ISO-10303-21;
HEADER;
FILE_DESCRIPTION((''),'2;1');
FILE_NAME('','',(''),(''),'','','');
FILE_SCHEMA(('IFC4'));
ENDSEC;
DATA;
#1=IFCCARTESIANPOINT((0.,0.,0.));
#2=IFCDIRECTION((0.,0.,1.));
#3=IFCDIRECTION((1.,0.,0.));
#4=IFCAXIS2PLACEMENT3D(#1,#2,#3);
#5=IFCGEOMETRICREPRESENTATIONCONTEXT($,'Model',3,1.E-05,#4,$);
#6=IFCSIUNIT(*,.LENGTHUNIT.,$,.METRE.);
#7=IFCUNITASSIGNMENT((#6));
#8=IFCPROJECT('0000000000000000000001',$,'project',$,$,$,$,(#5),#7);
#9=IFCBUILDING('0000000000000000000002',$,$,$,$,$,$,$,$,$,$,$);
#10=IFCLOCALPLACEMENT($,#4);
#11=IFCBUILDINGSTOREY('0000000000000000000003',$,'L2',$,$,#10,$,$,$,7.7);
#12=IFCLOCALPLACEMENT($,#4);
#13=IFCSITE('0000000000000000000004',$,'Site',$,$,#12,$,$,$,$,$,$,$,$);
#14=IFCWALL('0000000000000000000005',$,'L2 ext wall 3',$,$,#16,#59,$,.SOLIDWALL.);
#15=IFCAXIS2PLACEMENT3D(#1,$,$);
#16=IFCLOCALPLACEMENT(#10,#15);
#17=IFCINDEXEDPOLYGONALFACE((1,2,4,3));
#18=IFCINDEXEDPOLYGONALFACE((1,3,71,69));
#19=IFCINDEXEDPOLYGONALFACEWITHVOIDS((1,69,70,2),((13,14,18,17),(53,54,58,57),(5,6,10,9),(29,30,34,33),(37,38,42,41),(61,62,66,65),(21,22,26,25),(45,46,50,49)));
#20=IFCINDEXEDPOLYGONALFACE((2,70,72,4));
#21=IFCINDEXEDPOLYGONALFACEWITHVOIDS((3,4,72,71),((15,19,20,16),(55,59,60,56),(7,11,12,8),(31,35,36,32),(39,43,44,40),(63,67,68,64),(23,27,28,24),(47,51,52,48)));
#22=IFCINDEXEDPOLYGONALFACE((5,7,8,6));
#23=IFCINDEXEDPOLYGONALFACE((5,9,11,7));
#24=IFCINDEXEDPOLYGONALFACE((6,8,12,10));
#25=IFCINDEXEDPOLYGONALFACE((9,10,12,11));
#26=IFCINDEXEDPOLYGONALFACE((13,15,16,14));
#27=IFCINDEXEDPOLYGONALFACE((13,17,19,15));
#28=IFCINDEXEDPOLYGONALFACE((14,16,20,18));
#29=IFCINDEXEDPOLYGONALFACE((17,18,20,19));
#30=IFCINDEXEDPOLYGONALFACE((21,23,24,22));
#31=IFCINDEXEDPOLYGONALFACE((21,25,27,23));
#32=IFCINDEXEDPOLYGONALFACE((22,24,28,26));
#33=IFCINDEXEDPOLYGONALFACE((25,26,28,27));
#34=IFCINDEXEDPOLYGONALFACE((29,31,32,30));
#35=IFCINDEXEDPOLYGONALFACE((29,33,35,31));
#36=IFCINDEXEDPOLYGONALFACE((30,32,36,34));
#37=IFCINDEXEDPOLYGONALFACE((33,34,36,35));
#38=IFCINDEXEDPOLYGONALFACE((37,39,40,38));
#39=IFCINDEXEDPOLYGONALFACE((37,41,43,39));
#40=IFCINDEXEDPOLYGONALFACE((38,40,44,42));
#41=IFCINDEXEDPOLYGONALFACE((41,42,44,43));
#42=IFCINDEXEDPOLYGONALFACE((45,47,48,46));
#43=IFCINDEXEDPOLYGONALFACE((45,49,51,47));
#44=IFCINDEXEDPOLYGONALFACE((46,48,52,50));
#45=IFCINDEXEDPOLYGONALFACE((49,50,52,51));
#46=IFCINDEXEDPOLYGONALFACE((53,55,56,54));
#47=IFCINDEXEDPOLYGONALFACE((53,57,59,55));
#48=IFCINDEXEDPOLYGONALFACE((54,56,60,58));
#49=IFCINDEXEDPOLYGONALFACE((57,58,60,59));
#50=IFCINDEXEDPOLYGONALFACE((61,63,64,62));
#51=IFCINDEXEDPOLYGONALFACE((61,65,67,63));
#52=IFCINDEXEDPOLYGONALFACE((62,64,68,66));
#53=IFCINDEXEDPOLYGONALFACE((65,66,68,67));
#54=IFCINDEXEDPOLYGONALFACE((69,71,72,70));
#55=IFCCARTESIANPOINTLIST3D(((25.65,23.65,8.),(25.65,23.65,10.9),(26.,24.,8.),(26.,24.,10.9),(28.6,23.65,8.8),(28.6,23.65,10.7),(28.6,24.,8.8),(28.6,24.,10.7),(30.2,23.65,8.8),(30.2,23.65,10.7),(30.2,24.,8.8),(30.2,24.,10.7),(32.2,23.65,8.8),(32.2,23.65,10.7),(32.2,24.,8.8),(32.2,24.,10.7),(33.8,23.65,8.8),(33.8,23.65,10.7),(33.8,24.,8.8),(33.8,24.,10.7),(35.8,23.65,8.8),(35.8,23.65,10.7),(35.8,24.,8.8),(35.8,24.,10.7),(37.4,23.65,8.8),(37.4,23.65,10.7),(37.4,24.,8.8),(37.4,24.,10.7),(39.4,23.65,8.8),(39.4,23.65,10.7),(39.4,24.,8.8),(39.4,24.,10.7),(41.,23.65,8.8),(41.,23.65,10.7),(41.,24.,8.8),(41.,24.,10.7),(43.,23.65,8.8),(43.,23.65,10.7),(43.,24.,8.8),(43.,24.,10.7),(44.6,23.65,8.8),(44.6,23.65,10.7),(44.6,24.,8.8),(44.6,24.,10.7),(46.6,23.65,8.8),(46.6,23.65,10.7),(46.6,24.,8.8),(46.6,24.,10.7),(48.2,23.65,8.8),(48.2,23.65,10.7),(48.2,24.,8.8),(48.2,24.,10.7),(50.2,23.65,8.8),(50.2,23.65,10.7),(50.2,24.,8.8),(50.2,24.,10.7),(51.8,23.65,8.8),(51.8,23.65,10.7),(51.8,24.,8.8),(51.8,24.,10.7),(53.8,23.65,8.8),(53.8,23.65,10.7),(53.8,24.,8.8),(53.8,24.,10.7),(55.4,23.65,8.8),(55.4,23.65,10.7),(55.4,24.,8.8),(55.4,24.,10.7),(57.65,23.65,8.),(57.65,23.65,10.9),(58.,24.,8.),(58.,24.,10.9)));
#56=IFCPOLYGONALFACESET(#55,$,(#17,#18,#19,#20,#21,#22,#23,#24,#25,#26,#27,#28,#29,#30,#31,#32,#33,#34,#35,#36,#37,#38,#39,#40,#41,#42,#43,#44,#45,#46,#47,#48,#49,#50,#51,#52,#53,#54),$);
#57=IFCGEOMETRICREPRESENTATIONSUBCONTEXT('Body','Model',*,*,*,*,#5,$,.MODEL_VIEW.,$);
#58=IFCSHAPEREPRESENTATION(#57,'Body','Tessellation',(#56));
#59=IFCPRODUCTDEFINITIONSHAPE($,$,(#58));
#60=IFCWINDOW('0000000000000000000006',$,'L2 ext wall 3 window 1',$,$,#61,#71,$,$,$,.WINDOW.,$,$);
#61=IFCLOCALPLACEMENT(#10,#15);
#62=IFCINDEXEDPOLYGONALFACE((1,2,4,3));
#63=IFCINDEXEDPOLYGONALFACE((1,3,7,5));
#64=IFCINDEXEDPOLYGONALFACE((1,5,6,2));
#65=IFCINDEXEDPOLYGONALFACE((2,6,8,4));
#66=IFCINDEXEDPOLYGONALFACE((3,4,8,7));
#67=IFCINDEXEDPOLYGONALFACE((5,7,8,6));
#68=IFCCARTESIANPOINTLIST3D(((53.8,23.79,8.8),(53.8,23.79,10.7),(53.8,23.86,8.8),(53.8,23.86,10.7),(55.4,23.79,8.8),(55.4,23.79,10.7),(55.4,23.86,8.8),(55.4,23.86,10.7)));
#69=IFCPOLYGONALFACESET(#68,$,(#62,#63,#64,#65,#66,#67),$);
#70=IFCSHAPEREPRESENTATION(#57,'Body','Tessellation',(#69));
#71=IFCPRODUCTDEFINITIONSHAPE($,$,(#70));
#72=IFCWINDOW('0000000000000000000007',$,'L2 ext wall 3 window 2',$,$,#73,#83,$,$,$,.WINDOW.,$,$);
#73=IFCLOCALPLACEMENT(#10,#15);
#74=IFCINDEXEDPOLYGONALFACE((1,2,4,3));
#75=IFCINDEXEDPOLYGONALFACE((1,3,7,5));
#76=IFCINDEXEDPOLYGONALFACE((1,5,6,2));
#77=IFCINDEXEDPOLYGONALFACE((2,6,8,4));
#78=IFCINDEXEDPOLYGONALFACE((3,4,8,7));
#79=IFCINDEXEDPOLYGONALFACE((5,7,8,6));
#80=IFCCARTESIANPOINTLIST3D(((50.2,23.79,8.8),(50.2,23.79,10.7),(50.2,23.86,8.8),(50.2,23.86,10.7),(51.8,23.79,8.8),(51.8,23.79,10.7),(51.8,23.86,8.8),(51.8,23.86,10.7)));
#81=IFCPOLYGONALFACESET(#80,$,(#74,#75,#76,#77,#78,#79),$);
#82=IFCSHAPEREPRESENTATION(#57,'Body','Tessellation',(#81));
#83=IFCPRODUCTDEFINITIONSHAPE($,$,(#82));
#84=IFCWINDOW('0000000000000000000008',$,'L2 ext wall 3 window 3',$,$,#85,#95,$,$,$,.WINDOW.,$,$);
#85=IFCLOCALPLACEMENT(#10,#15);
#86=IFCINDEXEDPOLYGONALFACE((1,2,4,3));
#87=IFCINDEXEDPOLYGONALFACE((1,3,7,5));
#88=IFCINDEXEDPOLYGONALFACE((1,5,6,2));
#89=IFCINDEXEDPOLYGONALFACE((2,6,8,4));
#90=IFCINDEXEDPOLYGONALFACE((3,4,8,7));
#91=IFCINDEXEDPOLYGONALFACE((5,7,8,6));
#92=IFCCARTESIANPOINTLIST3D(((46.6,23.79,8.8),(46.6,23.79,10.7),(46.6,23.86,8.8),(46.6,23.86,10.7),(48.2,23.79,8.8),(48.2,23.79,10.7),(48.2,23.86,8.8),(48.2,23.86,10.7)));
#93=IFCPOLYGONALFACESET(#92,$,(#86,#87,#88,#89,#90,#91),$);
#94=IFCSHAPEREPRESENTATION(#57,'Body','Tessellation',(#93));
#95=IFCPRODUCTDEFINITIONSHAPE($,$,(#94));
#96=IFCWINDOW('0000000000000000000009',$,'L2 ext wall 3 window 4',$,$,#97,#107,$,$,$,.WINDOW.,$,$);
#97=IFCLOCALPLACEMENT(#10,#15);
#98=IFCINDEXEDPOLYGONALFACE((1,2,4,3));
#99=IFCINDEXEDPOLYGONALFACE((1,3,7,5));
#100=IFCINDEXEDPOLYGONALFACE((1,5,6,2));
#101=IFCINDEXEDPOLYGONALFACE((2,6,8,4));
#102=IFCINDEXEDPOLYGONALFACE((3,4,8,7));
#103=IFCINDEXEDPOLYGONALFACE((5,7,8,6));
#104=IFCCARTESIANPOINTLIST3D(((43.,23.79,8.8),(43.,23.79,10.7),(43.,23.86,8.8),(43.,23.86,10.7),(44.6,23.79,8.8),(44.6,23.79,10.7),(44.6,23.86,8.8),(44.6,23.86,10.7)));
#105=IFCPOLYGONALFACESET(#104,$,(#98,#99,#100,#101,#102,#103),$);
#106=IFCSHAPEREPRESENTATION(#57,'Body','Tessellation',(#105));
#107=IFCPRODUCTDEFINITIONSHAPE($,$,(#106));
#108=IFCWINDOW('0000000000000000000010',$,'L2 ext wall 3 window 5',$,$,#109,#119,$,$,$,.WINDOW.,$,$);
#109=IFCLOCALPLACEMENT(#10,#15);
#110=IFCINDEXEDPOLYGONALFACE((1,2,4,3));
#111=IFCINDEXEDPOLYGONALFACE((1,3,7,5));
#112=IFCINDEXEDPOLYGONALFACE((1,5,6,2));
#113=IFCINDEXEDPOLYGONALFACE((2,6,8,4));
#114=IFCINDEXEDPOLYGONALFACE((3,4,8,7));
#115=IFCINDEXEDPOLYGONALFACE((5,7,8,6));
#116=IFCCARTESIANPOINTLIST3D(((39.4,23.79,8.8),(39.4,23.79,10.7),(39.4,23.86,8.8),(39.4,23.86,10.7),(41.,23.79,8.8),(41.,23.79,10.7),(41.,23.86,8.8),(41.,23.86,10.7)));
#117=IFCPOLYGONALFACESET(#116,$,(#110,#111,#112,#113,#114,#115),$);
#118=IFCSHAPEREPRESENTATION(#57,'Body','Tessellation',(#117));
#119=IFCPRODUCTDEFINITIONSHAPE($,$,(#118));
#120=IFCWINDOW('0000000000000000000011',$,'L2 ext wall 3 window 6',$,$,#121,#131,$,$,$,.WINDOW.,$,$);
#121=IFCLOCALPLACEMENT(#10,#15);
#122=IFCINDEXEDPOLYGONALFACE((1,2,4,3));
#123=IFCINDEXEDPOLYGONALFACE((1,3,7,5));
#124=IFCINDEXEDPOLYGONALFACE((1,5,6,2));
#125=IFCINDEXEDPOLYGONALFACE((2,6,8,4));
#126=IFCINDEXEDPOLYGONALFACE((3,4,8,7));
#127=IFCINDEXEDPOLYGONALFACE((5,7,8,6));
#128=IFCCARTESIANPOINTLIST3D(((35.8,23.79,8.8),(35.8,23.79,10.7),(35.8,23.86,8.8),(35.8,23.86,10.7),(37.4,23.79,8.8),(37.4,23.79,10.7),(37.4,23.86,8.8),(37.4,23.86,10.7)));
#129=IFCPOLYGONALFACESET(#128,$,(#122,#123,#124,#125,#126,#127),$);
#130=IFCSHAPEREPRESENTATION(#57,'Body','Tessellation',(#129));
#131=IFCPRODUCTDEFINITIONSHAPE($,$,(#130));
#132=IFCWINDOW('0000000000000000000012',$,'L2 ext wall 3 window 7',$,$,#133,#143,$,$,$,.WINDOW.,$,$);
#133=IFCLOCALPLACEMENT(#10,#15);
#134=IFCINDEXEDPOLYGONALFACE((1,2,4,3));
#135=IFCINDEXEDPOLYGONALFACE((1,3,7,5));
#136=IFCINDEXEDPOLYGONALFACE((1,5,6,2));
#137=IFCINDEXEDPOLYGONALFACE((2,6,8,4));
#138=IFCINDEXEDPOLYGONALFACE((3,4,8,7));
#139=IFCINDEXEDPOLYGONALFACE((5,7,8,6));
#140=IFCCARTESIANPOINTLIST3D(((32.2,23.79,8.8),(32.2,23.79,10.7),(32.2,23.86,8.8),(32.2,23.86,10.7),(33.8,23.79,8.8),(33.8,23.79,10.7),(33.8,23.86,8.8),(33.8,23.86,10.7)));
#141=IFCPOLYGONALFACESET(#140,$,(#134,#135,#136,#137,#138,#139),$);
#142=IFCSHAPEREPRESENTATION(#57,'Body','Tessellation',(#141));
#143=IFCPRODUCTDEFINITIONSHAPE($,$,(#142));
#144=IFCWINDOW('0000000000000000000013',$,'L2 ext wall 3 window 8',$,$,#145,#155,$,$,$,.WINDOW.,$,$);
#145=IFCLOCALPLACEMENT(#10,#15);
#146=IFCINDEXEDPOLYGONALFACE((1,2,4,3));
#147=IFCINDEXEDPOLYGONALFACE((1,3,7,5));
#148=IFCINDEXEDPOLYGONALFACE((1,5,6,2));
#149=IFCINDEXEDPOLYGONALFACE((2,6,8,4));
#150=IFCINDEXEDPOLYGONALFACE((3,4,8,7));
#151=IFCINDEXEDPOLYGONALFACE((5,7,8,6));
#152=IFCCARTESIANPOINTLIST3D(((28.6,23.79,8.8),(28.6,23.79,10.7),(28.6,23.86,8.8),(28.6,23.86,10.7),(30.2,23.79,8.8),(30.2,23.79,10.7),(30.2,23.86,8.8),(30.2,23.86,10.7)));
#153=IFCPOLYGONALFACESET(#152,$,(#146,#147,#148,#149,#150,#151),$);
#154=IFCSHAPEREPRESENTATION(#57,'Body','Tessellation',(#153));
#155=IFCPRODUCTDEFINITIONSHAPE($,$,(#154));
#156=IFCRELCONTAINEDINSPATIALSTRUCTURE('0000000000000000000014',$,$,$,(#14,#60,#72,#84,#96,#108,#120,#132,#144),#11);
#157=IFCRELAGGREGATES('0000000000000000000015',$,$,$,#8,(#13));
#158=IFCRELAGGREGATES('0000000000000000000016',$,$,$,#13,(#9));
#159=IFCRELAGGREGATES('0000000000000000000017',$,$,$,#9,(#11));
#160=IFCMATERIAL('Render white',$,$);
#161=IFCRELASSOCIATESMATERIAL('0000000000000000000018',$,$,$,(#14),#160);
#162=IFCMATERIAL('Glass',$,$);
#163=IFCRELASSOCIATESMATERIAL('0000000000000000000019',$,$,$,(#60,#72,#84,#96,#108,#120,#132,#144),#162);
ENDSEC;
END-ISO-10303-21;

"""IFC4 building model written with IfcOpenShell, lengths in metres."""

from ifc_helpers import new_model, si_unit, frame, origin_with_axes, place, context, subcontext, project, spatial, polyline, outline, extrude, material, element, fill, save


model = new_model("IFC4")

# Units and contexts
model_context = context("Model", 3, precision=1e-05, world=origin_with_axes())
body_context = subcontext(model_context, "Body", "Model", "MODEL_VIEW")
ifc_project = project(units=[si_unit("LENGTHUNIT", "METRE")], contexts=[model_context])

# Site, building, storey
site_placement = place(None, origin_with_axes())
site = spatial("IfcSite", under=ifc_project, at=site_placement, Name="Site")
building = spatial("IfcBuilding", under=site)
storey_placement = place(None, origin_with_axes())
storey = spatial("IfcBuildingStorey", under=building, at=storey_placement, Name="L2", Elevation=7.7)

# Wall, openings, windows
ifc_material_1 = material(Name="Render white")
wall_1_placement = place(storey_placement, origin_with_axes())
wall_1 = element("IfcWall", 1, at=wall_1_placement, inside=storey, material=ifc_material_1, Name="L2 ext wall 3", PredefinedType="SOLIDWALL", context=body_context, shape_type="SweptSolid", body=[
    extrude(outline(polyline([(58.0, 24.0), (26.0, 24.0), (25.65, 23.65), (57.65, 23.65), (58.0, 24.0)])), frame((0.0, 0.0, 8.0), z_axis=(0.0, 0.0, 1.0), x_axis=(1.0, 0.0, 0.0)), (0.0, 0.0, 1.0), 2.9),
])
opening_1_placement = place(wall_1_placement, origin_with_axes())
opening_1 = element("IfcOpeningElement", 2, at=opening_1_placement, cuts=wall_1, context=body_context, shape_type="SweptSolid", body=[
    extrude(outline(polyline([(55.4, 24.05), (53.8, 24.05), (53.8, 23.6), (55.4, 23.6), (55.4, 24.05)])), frame((0.0, 0.0, 8.8), z_axis=(0.0, 0.0, 1.0), x_axis=(1.0, 0.0, 0.0)), (0.0, 0.0, 1.0), 1.9),
])
opening_2_placement = place(wall_1_placement, origin_with_axes())
opening_2 = element("IfcOpeningElement", 3, at=opening_2_placement, cuts=wall_1, context=body_context, shape_type="SweptSolid", body=[
    extrude(outline(polyline([(51.8, 24.05), (50.2, 24.05), (50.2, 23.6), (51.8, 23.6), (51.8, 24.05)])), frame((0.0, 0.0, 8.8), z_axis=(0.0, 0.0, 1.0), x_axis=(1.0, 0.0, 0.0)), (0.0, 0.0, 1.0), 1.9),
])
opening_3_placement = place(wall_1_placement, origin_with_axes())
opening_3 = element("IfcOpeningElement", 4, at=opening_3_placement, cuts=wall_1, context=body_context, shape_type="SweptSolid", body=[
    extrude(outline(polyline([(48.2, 24.05), (46.6, 24.05), (46.6, 23.6), (48.2, 23.6), (48.2, 24.05)])), frame((0.0, 0.0, 8.8), z_axis=(0.0, 0.0, 1.0), x_axis=(1.0, 0.0, 0.0)), (0.0, 0.0, 1.0), 1.9),
])
opening_4_placement = place(wall_1_placement, origin_with_axes())
opening_4 = element("IfcOpeningElement", 5, at=opening_4_placement, cuts=wall_1, context=body_context, shape_type="SweptSolid", body=[
    extrude(outline(polyline([(44.6, 24.05), (43.0, 24.05), (43.0, 23.6), (44.6, 23.6), (44.6, 24.05)])), frame((0.0, 0.0, 8.8), z_axis=(0.0, 0.0, 1.0), x_axis=(1.0, 0.0, 0.0)), (0.0, 0.0, 1.0), 1.9),
])
opening_5_placement = place(wall_1_placement, origin_with_axes())
opening_5 = element("IfcOpeningElement", 6, at=opening_5_placement, cuts=wall_1, context=body_context, shape_type="SweptSolid", body=[
    extrude(outline(polyline([(41.0, 24.05), (39.4, 24.05), (39.4, 23.6), (41.0, 23.6), (41.0, 24.05)])), frame((0.0, 0.0, 8.8), z_axis=(0.0, 0.0, 1.0), x_axis=(1.0, 0.0, 0.0)), (0.0, 0.0, 1.0), 1.9),
])
opening_6_placement = place(wall_1_placement, origin_with_axes())
opening_6 = element("IfcOpeningElement", 7, at=opening_6_placement, cuts=wall_1, context=body_context, shape_type="SweptSolid", body=[
    extrude(outline(polyline([(37.4, 24.05), (35.8, 24.05), (35.8, 23.6), (37.4, 23.6), (37.4, 24.05)])), frame((0.0, 0.0, 8.8), z_axis=(0.0, 0.0, 1.0), x_axis=(1.0, 0.0, 0.0)), (0.0, 0.0, 1.0), 1.9),
])
opening_7_placement = place(wall_1_placement, origin_with_axes())
opening_7 = element("IfcOpeningElement", 8, at=opening_7_placement, cuts=wall_1, context=body_context, shape_type="SweptSolid", body=[
    extrude(outline(polyline([(33.8, 24.05), (32.2, 24.05), (32.2, 23.6), (33.8, 23.6), (33.8, 24.05)])), frame((0.0, 0.0, 8.8), z_axis=(0.0, 0.0, 1.0), x_axis=(1.0, 0.0, 0.0)), (0.0, 0.0, 1.0), 1.9),
])
opening_8_placement = place(wall_1_placement, origin_with_axes())
opening_8 = element("IfcOpeningElement", 9, at=opening_8_placement, cuts=wall_1, context=body_context, shape_type="SweptSolid", body=[
    extrude(outline(polyline([(30.2, 24.05), (28.6, 24.05), (28.6, 23.6), (30.2, 23.6), (30.2, 24.05)])), frame((0.0, 0.0, 8.8), z_axis=(0.0, 0.0, 1.0), x_axis=(1.0, 0.0, 0.0)), (0.0, 0.0, 1.0), 1.9),
])
ifc_material_2 = material(Name="Glass")
window_1_placement = place(storey_placement, origin_with_axes())
window_1 = element("IfcWindow", 10, at=window_1_placement, inside=storey, material=ifc_material_2, Name="L2 ext wall 3 window 1", PredefinedType="WINDOW", context=body_context, shape_type="SweptSolid", body=[
    extrude(outline(polyline([(55.4, 23.86), (53.8, 23.86), (53.8, 23.79), (55.4, 23.79), (55.4, 23.86)])), frame((0.0, 0.0, 8.8), z_axis=(0.0, 0.0, 1.0), x_axis=(1.0, 0.0, 0.0)), (0.0, 0.0, 1.0), 1.9),
])
fill(opening_1, window_1)
window_2_placement = place(storey_placement, origin_with_axes())
window_2 = element("IfcWindow", 11, at=window_2_placement, inside=storey, material=ifc_material_2, Name="L2 ext wall 3 window 2", PredefinedType="WINDOW", context=body_context, shape_type="SweptSolid", body=[
    extrude(outline(polyline([(51.8, 23.86), (50.2, 23.86), (50.2, 23.79), (51.8, 23.79), (51.8, 23.86)])), frame((0.0, 0.0, 8.8), z_axis=(0.0, 0.0, 1.0), x_axis=(1.0, 0.0, 0.0)), (0.0, 0.0, 1.0), 1.9),
])
fill(opening_2, window_2)
window_3_placement = place(storey_placement, origin_with_axes())
window_3 = element("IfcWindow", 12, at=window_3_placement, inside=storey, material=ifc_material_2, Name="L2 ext wall 3 window 3", PredefinedType="WINDOW", context=body_context, shape_type="SweptSolid", body=[
    extrude(outline(polyline([(48.2, 23.86), (46.6, 23.86), (46.6, 23.79), (48.2, 23.79), (48.2, 23.86)])), frame((0.0, 0.0, 8.8), z_axis=(0.0, 0.0, 1.0), x_axis=(1.0, 0.0, 0.0)), (0.0, 0.0, 1.0), 1.9),
])
fill(opening_3, window_3)
window_4_placement = place(storey_placement, origin_with_axes())
window_4 = element("IfcWindow", 13, at=window_4_placement, inside=storey, material=ifc_material_2, Name="L2 ext wall 3 window 4", PredefinedType="WINDOW", context=body_context, shape_type="SweptSolid", body=[
    extrude(outline(polyline([(44.6, 23.86), (43.0, 23.86), (43.0, 23.79), (44.6, 23.79), (44.6, 23.86)])), frame((0.0, 0.0, 8.8), z_axis=(0.0, 0.0, 1.0), x_axis=(1.0, 0.0, 0.0)), (0.0, 0.0, 1.0), 1.9),
])
fill(opening_4, window_4)
window_5_placement = place(storey_placement, origin_with_axes())
window_5 = element("IfcWindow", 14, at=window_5_placement, inside=storey, material=ifc_material_2, Name="L2 ext wall 3 window 5", PredefinedType="WINDOW", context=body_context, shape_type="SweptSolid", body=[
    extrude(outline(polyline([(41.0, 23.86), (39.4, 23.86), (39.4, 23.79), (41.0, 23.79), (41.0, 23.86)])), frame((0.0, 0.0, 8.8), z_axis=(0.0, 0.0, 1.0), x_axis=(1.0, 0.0, 0.0)), (0.0, 0.0, 1.0), 1.9),
])
fill(opening_5, window_5)
window_6_placement = place(storey_placement, origin_with_axes())
window_6 = element("IfcWindow", 15, at=window_6_placement, inside=storey, material=ifc_material_2, Name="L2 ext wall 3 window 6", PredefinedType="WINDOW", context=body_context, shape_type="SweptSolid", body=[
    extrude(outline(polyline([(37.4, 23.86), (35.8, 23.86), (35.8, 23.79), (37.4, 23.79), (37.4, 23.86)])), frame((0.0, 0.0, 8.8), z_axis=(0.0, 0.0, 1.0), x_axis=(1.0, 0.0, 0.0)), (0.0, 0.0, 1.0), 1.9),
])
fill(opening_6, window_6)
window_7_placement = place(storey_placement, origin_with_axes())
window_7 = element("IfcWindow", 16, at=window_7_placement, inside=storey, material=ifc_material_2, Name="L2 ext wall 3 window 7", PredefinedType="WINDOW", context=body_context, shape_type="SweptSolid", body=[
    extrude(outline(polyline([(33.8, 23.86), (32.2, 23.86), (32.2, 23.79), (33.8, 23.79), (33.8, 23.86)])), frame((0.0, 0.0, 8.8), z_axis=(0.0, 0.0, 1.0), x_axis=(1.0, 0.0, 0.0)), (0.0, 0.0, 1.0), 1.9),
])
fill(opening_7, window_7)
window_8_placement = place(storey_placement, origin_with_axes())
window_8 = element("IfcWindow", 17, at=window_8_placement, inside=storey, material=ifc_material_2, Name="L2 ext wall 3 window 8", PredefinedType="WINDOW", context=body_context, shape_type="SweptSolid", body=[
    extrude(outline(polyline([(30.2, 23.86), (28.6, 23.86), (28.6, 23.79), (30.2, 23.79), (30.2, 23.86)])), frame((0.0, 0.0, 8.8), z_axis=(0.0, 0.0, 1.0), x_axis=(1.0, 0.0, 0.0)), (0.0, 0.0, 1.0), 1.9),
])
fill(opening_8, window_8)

save(model, "model.ifc")
